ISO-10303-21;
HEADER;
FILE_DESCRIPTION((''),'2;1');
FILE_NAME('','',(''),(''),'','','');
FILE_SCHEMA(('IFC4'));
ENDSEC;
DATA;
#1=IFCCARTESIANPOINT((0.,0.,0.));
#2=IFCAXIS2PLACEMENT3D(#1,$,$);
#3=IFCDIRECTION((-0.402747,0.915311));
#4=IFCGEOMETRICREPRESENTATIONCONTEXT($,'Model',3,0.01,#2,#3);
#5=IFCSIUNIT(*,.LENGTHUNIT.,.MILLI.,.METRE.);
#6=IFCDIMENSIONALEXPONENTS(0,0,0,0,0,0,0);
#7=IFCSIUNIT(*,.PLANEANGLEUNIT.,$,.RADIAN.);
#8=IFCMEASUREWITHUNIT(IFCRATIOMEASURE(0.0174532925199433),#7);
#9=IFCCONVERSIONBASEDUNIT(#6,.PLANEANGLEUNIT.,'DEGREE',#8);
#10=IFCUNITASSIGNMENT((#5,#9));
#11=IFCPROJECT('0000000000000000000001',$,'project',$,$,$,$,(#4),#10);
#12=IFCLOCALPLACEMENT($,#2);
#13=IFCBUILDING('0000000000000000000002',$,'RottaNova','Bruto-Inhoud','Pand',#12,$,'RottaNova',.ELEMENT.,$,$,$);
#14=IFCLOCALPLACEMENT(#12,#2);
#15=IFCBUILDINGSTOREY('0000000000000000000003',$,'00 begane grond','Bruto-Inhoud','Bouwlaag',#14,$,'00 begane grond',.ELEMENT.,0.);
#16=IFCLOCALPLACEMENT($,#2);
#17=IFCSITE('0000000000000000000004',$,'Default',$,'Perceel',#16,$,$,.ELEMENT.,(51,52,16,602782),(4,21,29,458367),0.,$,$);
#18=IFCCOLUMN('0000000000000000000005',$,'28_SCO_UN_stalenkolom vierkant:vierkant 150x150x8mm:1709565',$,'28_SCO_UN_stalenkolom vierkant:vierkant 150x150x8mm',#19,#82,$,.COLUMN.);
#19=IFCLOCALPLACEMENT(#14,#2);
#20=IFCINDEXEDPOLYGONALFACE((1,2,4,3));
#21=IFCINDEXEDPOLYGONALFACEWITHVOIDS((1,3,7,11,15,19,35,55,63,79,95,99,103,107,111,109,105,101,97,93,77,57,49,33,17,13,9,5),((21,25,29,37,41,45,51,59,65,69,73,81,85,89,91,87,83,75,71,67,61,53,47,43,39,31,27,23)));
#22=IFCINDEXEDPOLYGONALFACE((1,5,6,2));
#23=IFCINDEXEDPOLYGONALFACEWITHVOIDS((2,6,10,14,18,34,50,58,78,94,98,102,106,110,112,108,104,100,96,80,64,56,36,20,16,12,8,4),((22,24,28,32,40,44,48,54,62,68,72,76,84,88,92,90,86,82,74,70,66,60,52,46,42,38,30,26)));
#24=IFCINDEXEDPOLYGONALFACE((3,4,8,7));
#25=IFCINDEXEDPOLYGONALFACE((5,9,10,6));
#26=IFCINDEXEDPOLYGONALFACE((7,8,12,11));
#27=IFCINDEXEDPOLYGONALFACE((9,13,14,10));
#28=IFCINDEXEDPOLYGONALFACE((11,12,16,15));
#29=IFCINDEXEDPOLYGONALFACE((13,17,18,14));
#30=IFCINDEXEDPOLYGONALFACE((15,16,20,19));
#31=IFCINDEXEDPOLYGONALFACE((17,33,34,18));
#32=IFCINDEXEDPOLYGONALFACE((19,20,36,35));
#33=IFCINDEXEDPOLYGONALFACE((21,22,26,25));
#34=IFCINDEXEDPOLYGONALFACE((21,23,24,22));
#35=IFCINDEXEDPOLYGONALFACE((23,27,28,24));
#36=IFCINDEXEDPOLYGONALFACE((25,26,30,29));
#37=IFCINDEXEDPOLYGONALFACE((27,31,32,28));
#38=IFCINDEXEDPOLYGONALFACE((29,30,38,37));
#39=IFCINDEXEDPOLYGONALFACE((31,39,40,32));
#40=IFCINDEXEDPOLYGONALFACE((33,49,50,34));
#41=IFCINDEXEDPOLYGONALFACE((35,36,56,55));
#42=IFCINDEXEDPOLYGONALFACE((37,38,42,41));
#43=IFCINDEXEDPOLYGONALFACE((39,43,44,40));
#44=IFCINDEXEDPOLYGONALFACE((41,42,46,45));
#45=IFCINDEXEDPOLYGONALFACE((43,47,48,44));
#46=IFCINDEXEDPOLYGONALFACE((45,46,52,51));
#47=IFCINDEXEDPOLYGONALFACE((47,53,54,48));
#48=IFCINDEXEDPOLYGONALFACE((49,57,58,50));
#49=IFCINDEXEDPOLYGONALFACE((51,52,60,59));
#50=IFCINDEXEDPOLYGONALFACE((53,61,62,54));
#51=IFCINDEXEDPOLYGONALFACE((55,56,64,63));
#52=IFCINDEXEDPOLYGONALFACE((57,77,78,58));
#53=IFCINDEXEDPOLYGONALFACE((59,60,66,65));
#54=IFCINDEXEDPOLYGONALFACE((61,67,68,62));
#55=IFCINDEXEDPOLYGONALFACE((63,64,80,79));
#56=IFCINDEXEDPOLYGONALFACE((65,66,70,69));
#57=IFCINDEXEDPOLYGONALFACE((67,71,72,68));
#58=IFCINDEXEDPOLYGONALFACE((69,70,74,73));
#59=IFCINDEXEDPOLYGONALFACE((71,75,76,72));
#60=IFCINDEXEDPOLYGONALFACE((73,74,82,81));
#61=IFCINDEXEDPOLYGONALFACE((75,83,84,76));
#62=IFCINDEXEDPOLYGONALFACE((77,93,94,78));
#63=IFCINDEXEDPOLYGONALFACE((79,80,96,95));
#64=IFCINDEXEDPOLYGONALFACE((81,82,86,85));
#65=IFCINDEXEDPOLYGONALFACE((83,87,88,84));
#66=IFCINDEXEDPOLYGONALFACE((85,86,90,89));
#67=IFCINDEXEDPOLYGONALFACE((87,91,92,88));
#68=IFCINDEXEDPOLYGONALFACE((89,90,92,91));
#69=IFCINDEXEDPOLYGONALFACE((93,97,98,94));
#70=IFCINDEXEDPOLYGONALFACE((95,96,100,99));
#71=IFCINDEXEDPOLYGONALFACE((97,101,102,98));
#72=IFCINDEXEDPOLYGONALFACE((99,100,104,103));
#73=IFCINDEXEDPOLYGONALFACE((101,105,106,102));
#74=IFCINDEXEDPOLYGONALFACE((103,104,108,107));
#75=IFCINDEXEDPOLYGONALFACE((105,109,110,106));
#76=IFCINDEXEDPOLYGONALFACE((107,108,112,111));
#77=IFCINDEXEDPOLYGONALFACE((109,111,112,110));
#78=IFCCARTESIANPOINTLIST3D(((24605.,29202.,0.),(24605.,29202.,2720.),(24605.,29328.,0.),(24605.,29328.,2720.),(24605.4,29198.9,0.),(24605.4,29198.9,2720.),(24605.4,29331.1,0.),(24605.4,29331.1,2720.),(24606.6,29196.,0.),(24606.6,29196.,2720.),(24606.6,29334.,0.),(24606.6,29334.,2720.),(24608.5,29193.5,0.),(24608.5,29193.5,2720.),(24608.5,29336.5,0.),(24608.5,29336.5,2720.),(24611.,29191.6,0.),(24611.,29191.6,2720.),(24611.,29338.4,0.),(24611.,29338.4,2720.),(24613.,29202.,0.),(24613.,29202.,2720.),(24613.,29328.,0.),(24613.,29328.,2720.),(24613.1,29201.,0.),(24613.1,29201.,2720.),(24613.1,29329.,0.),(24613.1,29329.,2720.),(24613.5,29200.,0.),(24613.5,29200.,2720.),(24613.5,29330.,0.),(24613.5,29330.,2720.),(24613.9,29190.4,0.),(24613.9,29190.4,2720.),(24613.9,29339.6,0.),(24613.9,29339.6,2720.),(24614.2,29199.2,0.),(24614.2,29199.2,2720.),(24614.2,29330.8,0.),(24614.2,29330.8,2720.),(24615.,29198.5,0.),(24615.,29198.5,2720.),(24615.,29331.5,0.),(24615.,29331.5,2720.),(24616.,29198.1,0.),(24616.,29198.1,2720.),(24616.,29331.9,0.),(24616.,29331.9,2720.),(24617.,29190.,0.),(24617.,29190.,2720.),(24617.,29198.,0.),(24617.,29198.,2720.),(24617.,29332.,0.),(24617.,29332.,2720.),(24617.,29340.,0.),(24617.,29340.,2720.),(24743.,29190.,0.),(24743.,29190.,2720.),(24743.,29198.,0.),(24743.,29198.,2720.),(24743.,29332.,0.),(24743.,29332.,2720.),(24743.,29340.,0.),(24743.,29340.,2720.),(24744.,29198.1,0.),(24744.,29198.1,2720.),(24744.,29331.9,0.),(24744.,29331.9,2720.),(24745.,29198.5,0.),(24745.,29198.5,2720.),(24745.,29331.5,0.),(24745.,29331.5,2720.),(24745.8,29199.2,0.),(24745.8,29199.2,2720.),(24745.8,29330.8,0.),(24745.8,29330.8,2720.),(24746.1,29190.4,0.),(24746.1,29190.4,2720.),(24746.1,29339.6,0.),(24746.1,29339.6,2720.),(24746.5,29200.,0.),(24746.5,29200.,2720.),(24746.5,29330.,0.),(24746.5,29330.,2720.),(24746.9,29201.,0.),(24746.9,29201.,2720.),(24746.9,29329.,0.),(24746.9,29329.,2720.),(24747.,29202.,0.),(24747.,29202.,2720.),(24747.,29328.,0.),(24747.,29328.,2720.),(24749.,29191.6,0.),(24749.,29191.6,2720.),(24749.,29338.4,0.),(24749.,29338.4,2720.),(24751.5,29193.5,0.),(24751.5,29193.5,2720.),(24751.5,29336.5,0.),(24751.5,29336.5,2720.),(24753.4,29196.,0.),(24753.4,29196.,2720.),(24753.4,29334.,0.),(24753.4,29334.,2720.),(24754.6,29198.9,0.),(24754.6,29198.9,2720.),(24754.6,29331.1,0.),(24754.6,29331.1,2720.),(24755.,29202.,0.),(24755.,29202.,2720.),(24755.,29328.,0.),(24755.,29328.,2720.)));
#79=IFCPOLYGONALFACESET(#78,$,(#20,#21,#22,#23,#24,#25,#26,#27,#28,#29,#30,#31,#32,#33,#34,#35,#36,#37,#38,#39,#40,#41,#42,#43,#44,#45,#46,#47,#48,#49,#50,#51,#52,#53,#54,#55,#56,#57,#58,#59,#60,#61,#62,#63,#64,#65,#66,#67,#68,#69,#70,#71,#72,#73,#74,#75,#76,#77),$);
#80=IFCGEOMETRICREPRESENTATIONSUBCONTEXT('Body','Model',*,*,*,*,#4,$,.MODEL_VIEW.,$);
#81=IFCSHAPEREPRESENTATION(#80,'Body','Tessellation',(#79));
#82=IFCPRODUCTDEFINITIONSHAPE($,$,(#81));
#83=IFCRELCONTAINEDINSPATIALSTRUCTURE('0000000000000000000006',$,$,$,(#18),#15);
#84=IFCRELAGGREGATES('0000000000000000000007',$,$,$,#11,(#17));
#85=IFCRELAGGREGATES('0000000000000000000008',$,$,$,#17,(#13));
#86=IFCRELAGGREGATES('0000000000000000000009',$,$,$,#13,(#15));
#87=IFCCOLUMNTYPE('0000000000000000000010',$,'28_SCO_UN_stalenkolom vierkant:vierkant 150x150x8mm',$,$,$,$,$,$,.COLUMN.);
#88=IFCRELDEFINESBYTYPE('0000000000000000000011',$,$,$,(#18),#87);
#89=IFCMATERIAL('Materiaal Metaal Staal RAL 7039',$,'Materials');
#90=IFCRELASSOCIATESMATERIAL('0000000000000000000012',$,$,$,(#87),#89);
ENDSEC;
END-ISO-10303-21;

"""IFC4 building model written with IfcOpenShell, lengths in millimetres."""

from ifc_helpers import new_model, entity, si_unit, converted_unit, direction, frame, frame_2d, origin, place, context, subcontext, project, spatial, polyline, circle_curve, parameter, trimmed, segment, composite_curve, outline, extrude, source, transform, mapped, material, material_profile, profile_set, type_object, type_shapes, element, save


model = new_model("IFC4")

# Units and contexts
model_context = context("Model", 3, precision=0.01, world=origin(), true_north=direction((-0.402747, 0.915311)))
body_context = subcontext(model_context, "Body", "Model", "MODEL_VIEW")
ifc_project = project(units=[si_unit("LENGTHUNIT", "METRE", prefix="MILLI"), converted_unit("PLANEANGLEUNIT", "DEGREE", entity("IfcRatioMeasure", 0.0174532925199433), si_unit("PLANEANGLEUNIT", "RADIAN"), dimensions=[0, 0, 0, 0, 0, 0, 0])], contexts=[model_context])

# Site, building, storey
site_placement = place(None, origin())
site = spatial("IfcSite", under=ifc_project, at=site_placement, Name="Default", ObjectType="Perceel", CompositionType="ELEMENT", RefLatitude=(51, 52, 16, 602782), RefLongitude=(4, 21, 29, 458367), RefElevation=0.0)
building_placement = place(None, origin())
building = spatial("IfcBuilding", under=site, at=building_placement, Name="RottaNova", Description="Bruto-Inhoud", ObjectType="Pand", LongName="RottaNova", CompositionType="ELEMENT")
storey_placement = place(building_placement, origin())
storey = spatial("IfcBuildingStorey", under=building, at=storey_placement, Name="00 begane grond", Description="Bruto-Inhoud", ObjectType="Bouwlaag", LongName="00 begane grond", CompositionType="ELEMENT", Elevation=0.0)

# Column
ifc_material_1 = material(Name="Materiaal Metaal Staal RAL 7039", Category="Materials")
ifc_material_profile_1 = material_profile(ifc_material_1, outline(composite_curve([segment(trimmed(circle_curve(frame_2d((63.0, -63.0), x_axis=(1.0, 0.0)), 12.0), [parameter(270.0)], [parameter(360.0)], True, "PARAMETER"), True, "CONTINUOUS"), segment(polyline([(75.0, -63.0), (75.0, 63.0)]), True, "CONTINUOUS"), segment(trimmed(circle_curve(frame_2d((63.0, 63.0), x_axis=(1.0, 0.0)), 12.0), [parameter(360.0)], [parameter(90.0)], True, "PARAMETER"), True, "CONTINUOUS"), segment(polyline([(63.0, 75.0), (-63.0, 75.0)]), True, "CONTINUOUS"), segment(trimmed(circle_curve(frame_2d((-63.0, 63.0), x_axis=(1.0, 0.0)), 12.0), [parameter(90.0)], [parameter(180.0)], True, "PARAMETER"), True, "CONTINUOUS"), segment(polyline([(-75.0, 63.0), (-75.0, -63.0)]), True, "CONTINUOUS"), segment(trimmed(circle_curve(frame_2d((-63.0, -63.0), x_axis=(1.0, 0.0)), 12.0), [parameter(180.0)], [parameter(270.0)], True, "PARAMETER"), True, "CONTINUOUS"), segment(polyline([(-63.0, -75.0), (63.0, -75.0)]), True, "CONTINUOUS")], self_intersect=False), holes=[composite_curve([segment(polyline([(-67.0, -63.0), (-67.0, 63.0)]), True, "CONTINUOUS"), segment(trimmed(circle_curve(frame_2d((-63.0, 63.0), x_axis=(1.0, 0.0)), 4.0), [parameter(90.0)], [parameter(180.0)], True, "PARAMETER"), False, "CONTINUOUS"), segment(polyline([(-63.0, 67.0), (63.0, 67.0)]), True, "CONTINUOUS"), segment(trimmed(circle_curve(frame_2d((63.0, 63.0), x_axis=(1.0, 0.0)), 4.0), [parameter(0.0)], [parameter(90.0)], True, "PARAMETER"), False, "CONTINUOUS"), segment(polyline([(67.0, 63.0), (67.0, -63.0)]), True, "CONTINUOUS"), segment(trimmed(circle_curve(frame_2d((63.0, -63.0), x_axis=(1.0, 0.0)), 4.0), [parameter(270.0)], [parameter(0.0)], True, "PARAMETER"), False, "CONTINUOUS"), segment(polyline([(63.0, -67.0), (-63.0, -67.0)]), True, "CONTINUOUS"), segment(trimmed(circle_curve(frame_2d((-63.0, -63.0), x_axis=(1.0, 0.0)), 4.0), [parameter(180.0)], [parameter(270.0)], True, "PARAMETER"), False, "CONTINUOUS")], self_intersect=False)]), Name="vierkant 150x150x8mm")
ifc_profile_set_1 = profile_set([ifc_material_profile_1], Name="vierkant 150x150x8mm")
column_type_1 = type_object("IfcColumnType", Name="28_SCO_UN_stalenkolom vierkant:vierkant 150x150x8mm", PredefinedType="COLUMN", material=ifc_profile_set_1)
shared_shape_1 = source(origin(), body_context, "Body", "SweptSolid", [
    extrude(outline(composite_curve([segment(polyline([(-63.0, -75.0), (63.0, -75.0)]), True, "CONTINUOUS"), segment(trimmed(circle_curve(frame_2d((63.0, -63.0), x_axis=(-1.0, 0.0)), 12.0), [parameter(90.0)], [parameter(180.0)], True, "PARAMETER"), True, "CONTINUOUS"), segment(polyline([(75.0, -63.0), (75.0, 63.0)]), True, "CONTINUOUS"), segment(trimmed(circle_curve(frame_2d((63.0, 63.0), x_axis=(-1.0, 0.0)), 12.0), [parameter(180.0)], [parameter(270.0)], True, "PARAMETER"), True, "CONTINUOUS"), segment(polyline([(63.0, 75.0), (-63.0, 75.0)]), True, "CONTINUOUS"), segment(trimmed(circle_curve(frame_2d((-63.0, 63.0), x_axis=(-1.0, 0.0)), 12.0), [parameter(270.0)], [parameter(0.0)], True, "PARAMETER"), True, "CONTINUOUS"), segment(polyline([(-75.0, 63.0), (-75.0, -63.0)]), True, "CONTINUOUS"), segment(trimmed(circle_curve(frame_2d((-63.0, -63.0), x_axis=(-1.0, 0.0)), 12.0), [parameter(0.0)], [parameter(90.0)], True, "PARAMETER"), True, "CONTINUOUS")], self_intersect=False), holes=[composite_curve([segment(trimmed(circle_curve(frame_2d((63.0, -63.0), x_axis=(-1.0, 0.0)), 4.0), [parameter(90.0)], [parameter(180.0)], True, "PARAMETER"), False, "CONTINUOUS"), segment(polyline([(63.0, -67.0), (-63.0, -67.0)]), True, "CONTINUOUS"), segment(trimmed(circle_curve(frame_2d((-63.0, -63.0), x_axis=(-1.0, 0.0)), 4.0), [parameter(0.0)], [parameter(90.0)], True, "PARAMETER"), False, "CONTINUOUS"), segment(polyline([(-67.0, -63.0), (-67.0, 63.0)]), True, "CONTINUOUS"), segment(trimmed(circle_curve(frame_2d((-63.0, 63.0), x_axis=(-1.0, 0.0)), 4.0), [parameter(270.0)], [parameter(360.0)], True, "PARAMETER"), False, "CONTINUOUS"), segment(polyline([(-63.0, 67.0), (63.0, 67.0)]), True, "CONTINUOUS"), segment(trimmed(circle_curve(frame_2d((63.0, 63.0), x_axis=(-1.0, 0.0)), 4.0), [parameter(180.0)], [parameter(270.0)], True, "PARAMETER"), False, "CONTINUOUS"), segment(polyline([(67.0, 63.0), (67.0, -63.0)]), True, "CONTINUOUS")], self_intersect=False)]), frame((0.0, 0.0, 0.0), z_axis=(0.0, 0.0, 1.0), x_axis=(-1.0, 0.0, 0.0)), (0.0, 0.0, 1.0), 2720.0),
])
type_shapes(column_type_1, [shared_shape_1])
column_1_placement = place(storey_placement, frame((24680.0, 29265.0, 0.0)))
element("IfcColumn", 1, at=column_1_placement, inside=storey, type_object=column_type_1, Name="28_SCO_UN_stalenkolom vierkant:vierkant 150x150x8mm:1709565", ObjectType="28_SCO_UN_stalenkolom vierkant:vierkant 150x150x8mm", PredefinedType="COLUMN", context=body_context, shape_type="MappedRepresentation", body=[
    mapped(shared_shape_1, transform((0.0, 0.0, 0.0), scale=1.0)),
])

save(model, "model.ifc")
